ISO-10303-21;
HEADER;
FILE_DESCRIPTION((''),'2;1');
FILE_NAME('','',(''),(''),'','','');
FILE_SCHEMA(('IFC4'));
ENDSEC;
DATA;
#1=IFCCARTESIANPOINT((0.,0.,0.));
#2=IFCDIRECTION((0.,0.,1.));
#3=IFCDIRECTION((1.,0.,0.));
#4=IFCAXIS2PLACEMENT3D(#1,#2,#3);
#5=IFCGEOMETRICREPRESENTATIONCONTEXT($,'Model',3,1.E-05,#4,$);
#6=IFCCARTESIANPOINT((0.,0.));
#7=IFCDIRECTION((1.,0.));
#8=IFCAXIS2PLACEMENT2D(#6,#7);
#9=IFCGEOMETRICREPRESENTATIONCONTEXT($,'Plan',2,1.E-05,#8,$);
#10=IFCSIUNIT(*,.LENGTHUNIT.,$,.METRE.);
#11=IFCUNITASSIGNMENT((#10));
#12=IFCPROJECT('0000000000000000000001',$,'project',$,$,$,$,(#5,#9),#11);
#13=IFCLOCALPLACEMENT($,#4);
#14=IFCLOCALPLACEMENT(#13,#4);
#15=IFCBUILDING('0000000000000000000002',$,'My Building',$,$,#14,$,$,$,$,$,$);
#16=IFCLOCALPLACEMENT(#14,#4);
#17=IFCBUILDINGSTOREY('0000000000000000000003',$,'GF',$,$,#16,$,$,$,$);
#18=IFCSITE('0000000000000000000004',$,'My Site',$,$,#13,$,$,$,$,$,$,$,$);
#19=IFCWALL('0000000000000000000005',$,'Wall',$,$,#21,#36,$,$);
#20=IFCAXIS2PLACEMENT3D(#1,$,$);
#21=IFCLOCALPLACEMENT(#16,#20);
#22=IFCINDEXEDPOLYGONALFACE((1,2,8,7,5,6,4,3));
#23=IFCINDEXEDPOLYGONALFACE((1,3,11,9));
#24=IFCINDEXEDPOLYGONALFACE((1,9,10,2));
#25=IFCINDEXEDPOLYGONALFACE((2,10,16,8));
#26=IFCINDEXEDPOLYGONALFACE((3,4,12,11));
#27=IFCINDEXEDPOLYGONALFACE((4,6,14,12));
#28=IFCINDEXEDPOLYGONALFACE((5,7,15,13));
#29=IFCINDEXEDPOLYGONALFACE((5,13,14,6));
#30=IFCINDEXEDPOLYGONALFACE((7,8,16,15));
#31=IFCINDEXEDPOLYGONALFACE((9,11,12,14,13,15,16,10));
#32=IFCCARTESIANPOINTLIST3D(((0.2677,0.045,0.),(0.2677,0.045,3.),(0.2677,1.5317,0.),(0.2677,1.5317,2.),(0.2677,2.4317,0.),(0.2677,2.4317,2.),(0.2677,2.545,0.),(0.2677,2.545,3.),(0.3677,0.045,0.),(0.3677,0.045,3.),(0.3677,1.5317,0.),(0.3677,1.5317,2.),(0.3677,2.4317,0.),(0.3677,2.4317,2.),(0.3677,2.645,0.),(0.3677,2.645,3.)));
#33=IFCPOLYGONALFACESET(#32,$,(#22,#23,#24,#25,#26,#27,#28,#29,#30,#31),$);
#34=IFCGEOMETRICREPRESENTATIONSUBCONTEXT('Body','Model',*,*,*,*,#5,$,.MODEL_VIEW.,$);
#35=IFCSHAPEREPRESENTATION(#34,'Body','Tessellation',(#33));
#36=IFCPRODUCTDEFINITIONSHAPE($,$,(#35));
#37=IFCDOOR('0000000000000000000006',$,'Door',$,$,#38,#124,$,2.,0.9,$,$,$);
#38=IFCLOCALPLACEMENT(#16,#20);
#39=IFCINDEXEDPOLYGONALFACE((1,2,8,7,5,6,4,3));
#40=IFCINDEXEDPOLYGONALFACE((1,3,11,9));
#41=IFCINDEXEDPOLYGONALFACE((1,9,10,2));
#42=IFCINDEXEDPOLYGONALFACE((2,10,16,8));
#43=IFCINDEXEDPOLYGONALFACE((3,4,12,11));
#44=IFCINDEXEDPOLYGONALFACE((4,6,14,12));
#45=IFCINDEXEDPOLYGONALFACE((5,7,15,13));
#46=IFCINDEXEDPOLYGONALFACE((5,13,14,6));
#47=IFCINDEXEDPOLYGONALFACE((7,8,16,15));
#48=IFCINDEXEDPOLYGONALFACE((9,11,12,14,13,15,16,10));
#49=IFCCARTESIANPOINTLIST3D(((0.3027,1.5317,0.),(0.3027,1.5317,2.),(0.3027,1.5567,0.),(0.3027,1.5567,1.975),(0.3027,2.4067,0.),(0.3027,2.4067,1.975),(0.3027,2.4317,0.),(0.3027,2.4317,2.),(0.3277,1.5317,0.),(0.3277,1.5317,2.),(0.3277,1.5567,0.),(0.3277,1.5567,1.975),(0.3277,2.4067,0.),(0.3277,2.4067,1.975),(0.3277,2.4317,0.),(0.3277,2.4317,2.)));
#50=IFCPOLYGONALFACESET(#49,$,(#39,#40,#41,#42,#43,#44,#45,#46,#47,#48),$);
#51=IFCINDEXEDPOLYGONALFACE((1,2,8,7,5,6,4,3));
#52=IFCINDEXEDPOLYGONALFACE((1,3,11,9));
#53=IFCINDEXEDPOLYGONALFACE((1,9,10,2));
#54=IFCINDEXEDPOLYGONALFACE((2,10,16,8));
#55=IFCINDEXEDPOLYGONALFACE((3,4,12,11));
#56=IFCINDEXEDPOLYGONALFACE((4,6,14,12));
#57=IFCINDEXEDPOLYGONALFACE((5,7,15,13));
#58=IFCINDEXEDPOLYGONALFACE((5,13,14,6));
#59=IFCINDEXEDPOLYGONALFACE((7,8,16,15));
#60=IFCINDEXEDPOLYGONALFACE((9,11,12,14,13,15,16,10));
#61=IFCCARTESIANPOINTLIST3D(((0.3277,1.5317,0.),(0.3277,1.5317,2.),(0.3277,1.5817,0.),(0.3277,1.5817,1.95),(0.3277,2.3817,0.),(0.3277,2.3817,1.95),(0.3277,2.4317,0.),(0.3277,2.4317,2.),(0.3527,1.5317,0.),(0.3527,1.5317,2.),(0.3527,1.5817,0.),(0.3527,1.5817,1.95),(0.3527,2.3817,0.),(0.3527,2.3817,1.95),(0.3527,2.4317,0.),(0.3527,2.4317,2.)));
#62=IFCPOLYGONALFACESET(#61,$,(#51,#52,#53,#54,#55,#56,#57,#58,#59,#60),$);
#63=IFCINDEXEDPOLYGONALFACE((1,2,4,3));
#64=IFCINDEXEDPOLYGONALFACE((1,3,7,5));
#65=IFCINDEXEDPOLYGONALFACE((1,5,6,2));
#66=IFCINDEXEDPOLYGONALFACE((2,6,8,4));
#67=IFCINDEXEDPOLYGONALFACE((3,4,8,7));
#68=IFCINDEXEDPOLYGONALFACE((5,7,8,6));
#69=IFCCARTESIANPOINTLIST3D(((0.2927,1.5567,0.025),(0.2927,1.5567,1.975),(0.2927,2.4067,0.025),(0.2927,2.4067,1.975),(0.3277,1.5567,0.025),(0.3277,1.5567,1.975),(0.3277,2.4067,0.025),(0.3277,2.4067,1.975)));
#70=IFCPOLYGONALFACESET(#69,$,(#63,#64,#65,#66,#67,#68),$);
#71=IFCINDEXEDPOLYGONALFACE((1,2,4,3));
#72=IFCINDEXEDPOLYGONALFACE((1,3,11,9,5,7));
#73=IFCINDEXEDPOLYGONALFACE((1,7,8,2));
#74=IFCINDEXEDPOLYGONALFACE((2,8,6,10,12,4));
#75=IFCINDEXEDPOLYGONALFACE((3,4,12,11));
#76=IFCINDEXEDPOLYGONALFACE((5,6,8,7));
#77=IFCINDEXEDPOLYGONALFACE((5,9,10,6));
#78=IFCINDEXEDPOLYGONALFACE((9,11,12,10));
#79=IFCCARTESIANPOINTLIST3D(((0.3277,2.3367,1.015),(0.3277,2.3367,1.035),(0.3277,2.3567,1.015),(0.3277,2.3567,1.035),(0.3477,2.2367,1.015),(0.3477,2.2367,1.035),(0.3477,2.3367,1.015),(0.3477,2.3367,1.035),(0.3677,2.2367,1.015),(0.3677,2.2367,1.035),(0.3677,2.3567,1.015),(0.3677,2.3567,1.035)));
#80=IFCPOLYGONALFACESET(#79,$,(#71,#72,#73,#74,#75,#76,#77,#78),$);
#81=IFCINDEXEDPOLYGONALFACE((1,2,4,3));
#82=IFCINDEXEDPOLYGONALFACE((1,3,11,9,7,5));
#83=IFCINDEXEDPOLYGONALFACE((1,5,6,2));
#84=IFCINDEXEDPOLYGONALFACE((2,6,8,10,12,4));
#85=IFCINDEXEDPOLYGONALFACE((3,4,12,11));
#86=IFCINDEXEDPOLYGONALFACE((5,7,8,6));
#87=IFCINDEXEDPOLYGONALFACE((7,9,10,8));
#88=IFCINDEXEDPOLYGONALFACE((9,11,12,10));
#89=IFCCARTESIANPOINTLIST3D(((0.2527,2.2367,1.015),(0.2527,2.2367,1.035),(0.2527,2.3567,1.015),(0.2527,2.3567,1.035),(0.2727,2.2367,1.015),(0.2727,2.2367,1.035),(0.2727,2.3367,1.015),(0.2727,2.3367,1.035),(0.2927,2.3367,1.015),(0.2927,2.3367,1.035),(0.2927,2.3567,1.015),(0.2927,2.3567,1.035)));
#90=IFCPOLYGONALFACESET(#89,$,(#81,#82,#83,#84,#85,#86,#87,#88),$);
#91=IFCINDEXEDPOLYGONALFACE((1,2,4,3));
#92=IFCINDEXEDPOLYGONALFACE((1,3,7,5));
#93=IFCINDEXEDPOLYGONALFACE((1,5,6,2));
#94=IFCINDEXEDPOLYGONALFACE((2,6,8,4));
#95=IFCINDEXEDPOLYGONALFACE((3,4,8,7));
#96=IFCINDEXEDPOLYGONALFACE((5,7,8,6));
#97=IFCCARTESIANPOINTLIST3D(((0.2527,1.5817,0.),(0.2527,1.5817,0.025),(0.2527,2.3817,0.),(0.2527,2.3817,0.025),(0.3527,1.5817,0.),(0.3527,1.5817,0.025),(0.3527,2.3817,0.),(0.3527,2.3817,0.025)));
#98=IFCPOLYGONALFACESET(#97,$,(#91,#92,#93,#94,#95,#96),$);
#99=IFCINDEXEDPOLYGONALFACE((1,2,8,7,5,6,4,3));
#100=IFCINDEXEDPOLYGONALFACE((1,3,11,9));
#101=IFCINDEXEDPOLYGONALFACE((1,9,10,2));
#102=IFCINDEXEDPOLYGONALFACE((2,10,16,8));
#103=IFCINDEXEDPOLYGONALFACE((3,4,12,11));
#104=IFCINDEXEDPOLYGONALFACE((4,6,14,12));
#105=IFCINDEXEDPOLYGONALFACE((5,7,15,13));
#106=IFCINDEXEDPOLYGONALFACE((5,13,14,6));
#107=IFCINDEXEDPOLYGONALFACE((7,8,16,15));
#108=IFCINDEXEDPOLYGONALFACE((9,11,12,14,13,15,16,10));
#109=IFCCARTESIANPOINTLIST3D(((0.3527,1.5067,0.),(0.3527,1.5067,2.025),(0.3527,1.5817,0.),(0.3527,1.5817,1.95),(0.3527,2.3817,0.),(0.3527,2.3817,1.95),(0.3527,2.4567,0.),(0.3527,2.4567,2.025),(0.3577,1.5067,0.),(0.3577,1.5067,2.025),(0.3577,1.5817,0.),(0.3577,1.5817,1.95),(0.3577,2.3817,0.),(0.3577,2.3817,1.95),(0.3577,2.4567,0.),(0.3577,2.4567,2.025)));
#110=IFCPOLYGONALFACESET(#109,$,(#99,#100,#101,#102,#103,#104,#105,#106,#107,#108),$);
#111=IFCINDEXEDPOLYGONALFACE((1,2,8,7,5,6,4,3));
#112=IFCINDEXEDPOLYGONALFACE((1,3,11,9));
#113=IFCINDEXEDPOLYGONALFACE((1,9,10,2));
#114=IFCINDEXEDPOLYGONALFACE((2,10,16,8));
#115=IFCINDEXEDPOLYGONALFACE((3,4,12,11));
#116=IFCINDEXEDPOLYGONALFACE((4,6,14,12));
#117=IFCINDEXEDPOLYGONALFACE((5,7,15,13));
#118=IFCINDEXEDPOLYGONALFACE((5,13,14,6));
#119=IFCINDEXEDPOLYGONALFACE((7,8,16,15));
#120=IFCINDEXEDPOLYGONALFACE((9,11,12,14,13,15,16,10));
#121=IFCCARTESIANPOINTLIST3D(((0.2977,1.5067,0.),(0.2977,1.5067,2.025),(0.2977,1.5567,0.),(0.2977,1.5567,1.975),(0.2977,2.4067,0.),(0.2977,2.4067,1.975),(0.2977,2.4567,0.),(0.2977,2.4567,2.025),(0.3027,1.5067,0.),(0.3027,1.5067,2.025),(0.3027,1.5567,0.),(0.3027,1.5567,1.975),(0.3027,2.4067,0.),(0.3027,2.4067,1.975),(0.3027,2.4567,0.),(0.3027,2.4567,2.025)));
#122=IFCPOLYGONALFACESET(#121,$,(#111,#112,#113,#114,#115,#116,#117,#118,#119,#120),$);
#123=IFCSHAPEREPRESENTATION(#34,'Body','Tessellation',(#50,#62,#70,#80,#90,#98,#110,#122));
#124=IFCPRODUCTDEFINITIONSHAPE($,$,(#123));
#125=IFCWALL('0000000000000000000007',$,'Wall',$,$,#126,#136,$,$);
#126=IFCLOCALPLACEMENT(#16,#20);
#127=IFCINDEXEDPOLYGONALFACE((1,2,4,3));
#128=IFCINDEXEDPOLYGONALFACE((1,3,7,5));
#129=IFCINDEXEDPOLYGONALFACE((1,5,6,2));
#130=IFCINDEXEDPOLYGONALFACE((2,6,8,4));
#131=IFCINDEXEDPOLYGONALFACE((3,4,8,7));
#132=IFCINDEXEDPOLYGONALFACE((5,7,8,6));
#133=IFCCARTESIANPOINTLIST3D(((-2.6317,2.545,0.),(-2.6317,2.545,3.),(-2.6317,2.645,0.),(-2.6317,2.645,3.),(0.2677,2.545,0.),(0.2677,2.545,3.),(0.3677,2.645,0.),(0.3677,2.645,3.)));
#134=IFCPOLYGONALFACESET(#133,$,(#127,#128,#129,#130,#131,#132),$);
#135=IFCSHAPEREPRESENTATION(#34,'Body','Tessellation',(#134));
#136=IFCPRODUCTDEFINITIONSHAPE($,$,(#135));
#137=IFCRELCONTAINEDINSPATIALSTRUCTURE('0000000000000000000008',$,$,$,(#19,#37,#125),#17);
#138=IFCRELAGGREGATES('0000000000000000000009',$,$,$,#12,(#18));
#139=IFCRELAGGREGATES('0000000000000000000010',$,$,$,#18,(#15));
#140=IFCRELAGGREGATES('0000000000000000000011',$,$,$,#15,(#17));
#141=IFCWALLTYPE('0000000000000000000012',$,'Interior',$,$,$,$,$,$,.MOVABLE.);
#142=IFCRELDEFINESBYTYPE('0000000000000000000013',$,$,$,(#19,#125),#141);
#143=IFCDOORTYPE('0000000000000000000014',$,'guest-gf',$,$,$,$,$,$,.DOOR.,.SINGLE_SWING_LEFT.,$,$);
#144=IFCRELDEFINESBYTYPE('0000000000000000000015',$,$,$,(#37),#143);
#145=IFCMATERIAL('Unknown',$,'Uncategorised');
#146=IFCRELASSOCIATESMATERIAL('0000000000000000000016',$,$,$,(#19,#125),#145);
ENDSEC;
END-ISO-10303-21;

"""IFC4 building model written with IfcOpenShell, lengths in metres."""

from ifc_helpers import new_model, entity, si_unit, frame, origin_with_axes, origin_2d_with_axis, place, context, subcontext, project, spatial, line, indexed_curve, outline, extrude, shape, source, transform, mapped, material, type_object, type_shapes, element, fill, save


model = new_model("IFC4")

# Units and contexts
model_context = context("Model", 3, precision=1e-05, world=origin_with_axes())
plan_context = context("Plan", 2, precision=1e-05, world=origin_2d_with_axis())
body_context_1 = subcontext(model_context, "Body", "Model", "MODEL_VIEW")
body_context_2 = subcontext(plan_context, "Body", "Plan", "PLAN_VIEW")
ifc_project = project(units=[si_unit("LENGTHUNIT", "METRE")], contexts=[model_context, plan_context])

# Site, building, storey
site_placement = place(None, origin_with_axes())
site = spatial("IfcSite", under=ifc_project, at=site_placement, Name="My Site")
building_placement = place(site_placement, origin_with_axes())
building = spatial("IfcBuilding", under=site, at=building_placement, Name="My Building")
storey_placement = place(building_placement, origin_with_axes())
storey = spatial("IfcBuildingStorey", under=building, at=storey_placement, Name="GF")

# Shared definitions
ifc_material = material(Name="Unknown", Category="Uncategorised")

# Shared definitions
wall_type_1 = type_object("IfcWallType", Name="Interior", PredefinedType="MOVABLE")

# Wall, opening, door
wall_1_placement = place(storey_placement, frame((0.3677, 0.045, 0.0), z_axis=(0.0, 0.0, 1.0), x_axis=(0.0, 1.0, 0.0)))
wall_1 = element("IfcWall", 1, at=wall_1_placement, inside=storey, type_object=wall_type_1, material=ifc_material, Name="Wall", context=body_context_1, shape_type="SweptSolid", body=[
    extrude(outline(indexed_curve([(0.0, 0.0), (0.0, 0.1), (2.5, 0.1), (2.6, 0.0)], segments=[line(1, 2, 3, 4, 1)])), origin_with_axes(), (0.0, 0.0, 1.0), 3.0),
])
shared_shape_1 = source(origin_with_axes(), body_context_1, "Body", "SweptSolid", [
    extrude(outline(indexed_curve([(0.0, 0.0), (0.9, 0.0), (0.9, 2.0), (0.0, 2.0)], segments=[line(1, 2, 3, 4, 1)])), frame((0.0, -0.6, 0.0), z_axis=(0.0, -1.0, 0.0), x_axis=(1.0, 0.0, 0.0)), (0.0, 0.0, -1.0), 1.2),
])
opening_1_placement = place(wall_1_placement, frame((1.4867, 0.015, 0.0), z_axis=(0.0, 0.0, 1.0), x_axis=(1.0, 0.0, 0.0)))
opening_1 = element("IfcOpeningElement", 2, at=opening_1_placement, cuts=wall_1, PredefinedType="OPENING", context=body_context_1, shape_type="MappedRepresentation", body=[
    mapped(shared_shape_1, transform((0.0, 0.0, 0.0), x_axis=(1.0, 0.0, 0.0), y_axis=(0.0, 1.0, 0.0), z_axis=(0.0, 0.0, 1.0), scale=1.0)),
])
door_type_1 = type_object("IfcDoorType", Name="guest-gf", OperationType="SINGLE_SWING_LEFT", PredefinedType="DOOR")
shared_shape_2 = source(origin_with_axes(), body_context_1, "Body", "SweptSolid", [
    extrude(outline(indexed_curve([(0.0, 0.0), (0.0, 2.0), (0.9, 2.0), (0.9, 0.0), (0.875, 0.0), (0.875, 1.975), (0.025, 1.975), (0.025, 0.0)], segments=[line(1, 2, 3, 4, 5, 6, 7, 8, 1)])), frame((0.0, 0.025, 0.0), z_axis=(0.0, -1.0, 0.0), x_axis=(1.0, 0.0, 0.0)), (0.0, 0.0, -1.0), 0.025),
    extrude(outline(indexed_curve([(0.0, 0.0), (0.0, 2.0), (0.9, 2.0), (0.9, 0.0), (0.85, 0.0), (0.85, 1.95), (0.05, 1.95), (0.05, 0.0)], segments=[line(1, 2, 3, 4, 5, 6, 7, 8, 1)])), frame((0.0, 0.0, 0.0), z_axis=(0.0, -1.0, 0.0), x_axis=(1.0, 0.0, 0.0)), (0.0, 0.0, -1.0), 0.025),
    extrude(outline(indexed_curve([(0.0, 0.0), (0.85, 0.0), (0.85, 0.035), (0.0, 0.035)], segments=[line(1, 2, 3, 4, 1)])), frame((0.025, 0.025, 0.025), z_axis=(0.0, 0.0, 1.0), x_axis=(1.0, 0.0, 0.0)), (0.0, 0.0, 1.0), 1.95),
    extrude(outline(indexed_curve([(0.0, 0.0), (0.0, -0.04), (-0.12, -0.04), (-0.12, -0.02), (-0.02, -0.02), (-0.02, 0.0)], segments=[line(1, 2, 3, 4, 5, 6, 1)])), frame((0.825, 0.025, 1.015), z_axis=(0.0, 0.0, 1.0), x_axis=(1.0, 0.0, 0.0)), (0.0, 0.0, 1.0), 0.02),
    extrude(outline(indexed_curve([(0.0, 0.0), (0.0, 0.04), (-0.12, 0.04), (-0.12, 0.02), (-0.02, 0.02), (-0.02, 0.0)], segments=[line(1, 2, 3, 4, 5, 6, 1)])), frame((0.825, 0.06, 1.015), z_axis=(0.0, 0.0, 1.0), x_axis=(1.0, 0.0, 0.0)), (0.0, 0.0, 1.0), 0.02),
    extrude(outline(indexed_curve([(0.0, 0.0), (0.8, 0.0), (0.8, 0.1), (0.0, 0.1)], segments=[line(1, 2, 3, 4, 1)])), frame((0.05, 0.0, 0.0), z_axis=(0.0, 0.0, 1.0), x_axis=(1.0, 0.0, 0.0)), (0.0, 0.0, 1.0), 0.025),
    extrude(outline(indexed_curve([(0.0, 0.0), (0.0, 2.025), (0.95, 2.025), (0.95, 0.0), (0.875, 0.0), (0.875, 1.95), (0.075, 1.95), (0.075, 0.0)], segments=[line(1, 2, 3, 4, 5, 6, 7, 8, 1)])), frame((-0.025, -0.005, 0.0), z_axis=(0.0, -1.0, 0.0), x_axis=(1.0, 0.0, 0.0)), (0.0, 0.0, -1.0), 0.005),
    extrude(outline(indexed_curve([(0.0, 0.0), (0.0, 2.025), (0.95, 2.025), (0.95, 0.0), (0.9, 0.0), (0.9, 1.975), (0.05, 1.975), (0.05, 0.0)], segments=[line(1, 2, 3, 4, 5, 6, 7, 8, 1)])), frame((-0.025, 0.05, 0.0), z_axis=(0.0, -1.0, 0.0), x_axis=(1.0, 0.0, 0.0)), (0.0, 0.0, -1.0), 0.005),
])
shared_shape_3 = source(origin_with_axes(), body_context_2, "Body", "Curve2D", [
    entity("IfcIndexedPolyCurve", entity("IfcCartesianPointList2D", [[0.0, 0.0], [0.0, 0.05], [0.025, 0.05], [0.025, 0.025], [0.05, 0.025], [0.05, 0.0]]), [entity("IfcLineIndex", [1, 2, 3, 4, 5, 6, 1])]),
    entity("IfcIndexedPolyCurve", entity("IfcCartesianPointList2D", [[0.9, 0.0], [0.9, 0.05], [0.875, 0.05], [0.875, 0.025], [0.85, 0.025], [0.85, 0.0]]), [entity("IfcLineIndex", [1, 2, 3, 4, 5, 6, 1])]),
    entity("IfcTrimmedCurve", entity("IfcEllipse", entity("IfcAxis2Placement2D", entity("IfcCartesianPoint", [0.06, 0.05]), entity("IfcDirection", [1.0, 0.0])), 0.815, 0.85), [entity("IfcCartesianPoint", [0.875, 0.05])], [entity("IfcCartesianPoint", [0.06, 0.9])], True, "CARTESIAN"),
    entity("IfcIndexedPolyCurve", entity("IfcCartesianPointList2D", [[0.025, 0.05], [0.06, 0.05], [0.06, 0.9], [0.025, 0.9]]), [entity("IfcLineIndex", [1, 2, 3, 4, 1])]),
])
type_shapes(door_type_1, [shared_shape_2, shared_shape_3])
door_1_placement = place(opening_1_placement, frame((0.0, 0.0, 0.0), z_axis=(0.0, 0.0, 1.0), x_axis=(1.0, 0.0, 0.0)))
door_1 = element("IfcDoor", 3, at=door_1_placement, inside=storey, type_object=door_type_1, Name="Door", OverallHeight=2.0, OverallWidth=0.9, shapes=[
    shape(body_context_1, "Body", "MappedRepresentation", [mapped(shared_shape_2, transform((0.0, 0.0, 0.0), x_axis=(1.0, 0.0, 0.0), y_axis=(0.0, 1.0, 0.0), z_axis=(0.0, 0.0, 1.0), scale=1.0))]),
    shape(body_context_2, "Body", "MappedRepresentation", [mapped(shared_shape_3, transform((0.0, 0.0, 0.0), x_axis=(1.0, 0.0, 0.0), y_axis=(0.0, 1.0, 0.0), z_axis=(0.0, 0.0, 1.0), scale=1.0))]),
])
fill(opening_1, door_1)

# Wall
wall_2_placement = place(storey_placement, frame((0.3677, 2.645, 0.0), z_axis=(0.0, 0.0, 1.0), x_axis=(-1.0, 0.0, 0.0)))
element("IfcWall", 4, at=wall_2_placement, inside=storey, type_object=wall_type_1, material=ifc_material, Name="Wall", context=body_context_1, shape_type="SweptSolid", body=[
    extrude(outline(indexed_curve([(0.0, 0.0), (0.1, 0.1), (2.9994, 0.1), (2.9994, 0.0)], segments=[line(1, 2, 3, 4, 1)])), origin_with_axes(), (0.0, 0.0, 1.0), 3.0),
])

save(model, "model.ifc")
